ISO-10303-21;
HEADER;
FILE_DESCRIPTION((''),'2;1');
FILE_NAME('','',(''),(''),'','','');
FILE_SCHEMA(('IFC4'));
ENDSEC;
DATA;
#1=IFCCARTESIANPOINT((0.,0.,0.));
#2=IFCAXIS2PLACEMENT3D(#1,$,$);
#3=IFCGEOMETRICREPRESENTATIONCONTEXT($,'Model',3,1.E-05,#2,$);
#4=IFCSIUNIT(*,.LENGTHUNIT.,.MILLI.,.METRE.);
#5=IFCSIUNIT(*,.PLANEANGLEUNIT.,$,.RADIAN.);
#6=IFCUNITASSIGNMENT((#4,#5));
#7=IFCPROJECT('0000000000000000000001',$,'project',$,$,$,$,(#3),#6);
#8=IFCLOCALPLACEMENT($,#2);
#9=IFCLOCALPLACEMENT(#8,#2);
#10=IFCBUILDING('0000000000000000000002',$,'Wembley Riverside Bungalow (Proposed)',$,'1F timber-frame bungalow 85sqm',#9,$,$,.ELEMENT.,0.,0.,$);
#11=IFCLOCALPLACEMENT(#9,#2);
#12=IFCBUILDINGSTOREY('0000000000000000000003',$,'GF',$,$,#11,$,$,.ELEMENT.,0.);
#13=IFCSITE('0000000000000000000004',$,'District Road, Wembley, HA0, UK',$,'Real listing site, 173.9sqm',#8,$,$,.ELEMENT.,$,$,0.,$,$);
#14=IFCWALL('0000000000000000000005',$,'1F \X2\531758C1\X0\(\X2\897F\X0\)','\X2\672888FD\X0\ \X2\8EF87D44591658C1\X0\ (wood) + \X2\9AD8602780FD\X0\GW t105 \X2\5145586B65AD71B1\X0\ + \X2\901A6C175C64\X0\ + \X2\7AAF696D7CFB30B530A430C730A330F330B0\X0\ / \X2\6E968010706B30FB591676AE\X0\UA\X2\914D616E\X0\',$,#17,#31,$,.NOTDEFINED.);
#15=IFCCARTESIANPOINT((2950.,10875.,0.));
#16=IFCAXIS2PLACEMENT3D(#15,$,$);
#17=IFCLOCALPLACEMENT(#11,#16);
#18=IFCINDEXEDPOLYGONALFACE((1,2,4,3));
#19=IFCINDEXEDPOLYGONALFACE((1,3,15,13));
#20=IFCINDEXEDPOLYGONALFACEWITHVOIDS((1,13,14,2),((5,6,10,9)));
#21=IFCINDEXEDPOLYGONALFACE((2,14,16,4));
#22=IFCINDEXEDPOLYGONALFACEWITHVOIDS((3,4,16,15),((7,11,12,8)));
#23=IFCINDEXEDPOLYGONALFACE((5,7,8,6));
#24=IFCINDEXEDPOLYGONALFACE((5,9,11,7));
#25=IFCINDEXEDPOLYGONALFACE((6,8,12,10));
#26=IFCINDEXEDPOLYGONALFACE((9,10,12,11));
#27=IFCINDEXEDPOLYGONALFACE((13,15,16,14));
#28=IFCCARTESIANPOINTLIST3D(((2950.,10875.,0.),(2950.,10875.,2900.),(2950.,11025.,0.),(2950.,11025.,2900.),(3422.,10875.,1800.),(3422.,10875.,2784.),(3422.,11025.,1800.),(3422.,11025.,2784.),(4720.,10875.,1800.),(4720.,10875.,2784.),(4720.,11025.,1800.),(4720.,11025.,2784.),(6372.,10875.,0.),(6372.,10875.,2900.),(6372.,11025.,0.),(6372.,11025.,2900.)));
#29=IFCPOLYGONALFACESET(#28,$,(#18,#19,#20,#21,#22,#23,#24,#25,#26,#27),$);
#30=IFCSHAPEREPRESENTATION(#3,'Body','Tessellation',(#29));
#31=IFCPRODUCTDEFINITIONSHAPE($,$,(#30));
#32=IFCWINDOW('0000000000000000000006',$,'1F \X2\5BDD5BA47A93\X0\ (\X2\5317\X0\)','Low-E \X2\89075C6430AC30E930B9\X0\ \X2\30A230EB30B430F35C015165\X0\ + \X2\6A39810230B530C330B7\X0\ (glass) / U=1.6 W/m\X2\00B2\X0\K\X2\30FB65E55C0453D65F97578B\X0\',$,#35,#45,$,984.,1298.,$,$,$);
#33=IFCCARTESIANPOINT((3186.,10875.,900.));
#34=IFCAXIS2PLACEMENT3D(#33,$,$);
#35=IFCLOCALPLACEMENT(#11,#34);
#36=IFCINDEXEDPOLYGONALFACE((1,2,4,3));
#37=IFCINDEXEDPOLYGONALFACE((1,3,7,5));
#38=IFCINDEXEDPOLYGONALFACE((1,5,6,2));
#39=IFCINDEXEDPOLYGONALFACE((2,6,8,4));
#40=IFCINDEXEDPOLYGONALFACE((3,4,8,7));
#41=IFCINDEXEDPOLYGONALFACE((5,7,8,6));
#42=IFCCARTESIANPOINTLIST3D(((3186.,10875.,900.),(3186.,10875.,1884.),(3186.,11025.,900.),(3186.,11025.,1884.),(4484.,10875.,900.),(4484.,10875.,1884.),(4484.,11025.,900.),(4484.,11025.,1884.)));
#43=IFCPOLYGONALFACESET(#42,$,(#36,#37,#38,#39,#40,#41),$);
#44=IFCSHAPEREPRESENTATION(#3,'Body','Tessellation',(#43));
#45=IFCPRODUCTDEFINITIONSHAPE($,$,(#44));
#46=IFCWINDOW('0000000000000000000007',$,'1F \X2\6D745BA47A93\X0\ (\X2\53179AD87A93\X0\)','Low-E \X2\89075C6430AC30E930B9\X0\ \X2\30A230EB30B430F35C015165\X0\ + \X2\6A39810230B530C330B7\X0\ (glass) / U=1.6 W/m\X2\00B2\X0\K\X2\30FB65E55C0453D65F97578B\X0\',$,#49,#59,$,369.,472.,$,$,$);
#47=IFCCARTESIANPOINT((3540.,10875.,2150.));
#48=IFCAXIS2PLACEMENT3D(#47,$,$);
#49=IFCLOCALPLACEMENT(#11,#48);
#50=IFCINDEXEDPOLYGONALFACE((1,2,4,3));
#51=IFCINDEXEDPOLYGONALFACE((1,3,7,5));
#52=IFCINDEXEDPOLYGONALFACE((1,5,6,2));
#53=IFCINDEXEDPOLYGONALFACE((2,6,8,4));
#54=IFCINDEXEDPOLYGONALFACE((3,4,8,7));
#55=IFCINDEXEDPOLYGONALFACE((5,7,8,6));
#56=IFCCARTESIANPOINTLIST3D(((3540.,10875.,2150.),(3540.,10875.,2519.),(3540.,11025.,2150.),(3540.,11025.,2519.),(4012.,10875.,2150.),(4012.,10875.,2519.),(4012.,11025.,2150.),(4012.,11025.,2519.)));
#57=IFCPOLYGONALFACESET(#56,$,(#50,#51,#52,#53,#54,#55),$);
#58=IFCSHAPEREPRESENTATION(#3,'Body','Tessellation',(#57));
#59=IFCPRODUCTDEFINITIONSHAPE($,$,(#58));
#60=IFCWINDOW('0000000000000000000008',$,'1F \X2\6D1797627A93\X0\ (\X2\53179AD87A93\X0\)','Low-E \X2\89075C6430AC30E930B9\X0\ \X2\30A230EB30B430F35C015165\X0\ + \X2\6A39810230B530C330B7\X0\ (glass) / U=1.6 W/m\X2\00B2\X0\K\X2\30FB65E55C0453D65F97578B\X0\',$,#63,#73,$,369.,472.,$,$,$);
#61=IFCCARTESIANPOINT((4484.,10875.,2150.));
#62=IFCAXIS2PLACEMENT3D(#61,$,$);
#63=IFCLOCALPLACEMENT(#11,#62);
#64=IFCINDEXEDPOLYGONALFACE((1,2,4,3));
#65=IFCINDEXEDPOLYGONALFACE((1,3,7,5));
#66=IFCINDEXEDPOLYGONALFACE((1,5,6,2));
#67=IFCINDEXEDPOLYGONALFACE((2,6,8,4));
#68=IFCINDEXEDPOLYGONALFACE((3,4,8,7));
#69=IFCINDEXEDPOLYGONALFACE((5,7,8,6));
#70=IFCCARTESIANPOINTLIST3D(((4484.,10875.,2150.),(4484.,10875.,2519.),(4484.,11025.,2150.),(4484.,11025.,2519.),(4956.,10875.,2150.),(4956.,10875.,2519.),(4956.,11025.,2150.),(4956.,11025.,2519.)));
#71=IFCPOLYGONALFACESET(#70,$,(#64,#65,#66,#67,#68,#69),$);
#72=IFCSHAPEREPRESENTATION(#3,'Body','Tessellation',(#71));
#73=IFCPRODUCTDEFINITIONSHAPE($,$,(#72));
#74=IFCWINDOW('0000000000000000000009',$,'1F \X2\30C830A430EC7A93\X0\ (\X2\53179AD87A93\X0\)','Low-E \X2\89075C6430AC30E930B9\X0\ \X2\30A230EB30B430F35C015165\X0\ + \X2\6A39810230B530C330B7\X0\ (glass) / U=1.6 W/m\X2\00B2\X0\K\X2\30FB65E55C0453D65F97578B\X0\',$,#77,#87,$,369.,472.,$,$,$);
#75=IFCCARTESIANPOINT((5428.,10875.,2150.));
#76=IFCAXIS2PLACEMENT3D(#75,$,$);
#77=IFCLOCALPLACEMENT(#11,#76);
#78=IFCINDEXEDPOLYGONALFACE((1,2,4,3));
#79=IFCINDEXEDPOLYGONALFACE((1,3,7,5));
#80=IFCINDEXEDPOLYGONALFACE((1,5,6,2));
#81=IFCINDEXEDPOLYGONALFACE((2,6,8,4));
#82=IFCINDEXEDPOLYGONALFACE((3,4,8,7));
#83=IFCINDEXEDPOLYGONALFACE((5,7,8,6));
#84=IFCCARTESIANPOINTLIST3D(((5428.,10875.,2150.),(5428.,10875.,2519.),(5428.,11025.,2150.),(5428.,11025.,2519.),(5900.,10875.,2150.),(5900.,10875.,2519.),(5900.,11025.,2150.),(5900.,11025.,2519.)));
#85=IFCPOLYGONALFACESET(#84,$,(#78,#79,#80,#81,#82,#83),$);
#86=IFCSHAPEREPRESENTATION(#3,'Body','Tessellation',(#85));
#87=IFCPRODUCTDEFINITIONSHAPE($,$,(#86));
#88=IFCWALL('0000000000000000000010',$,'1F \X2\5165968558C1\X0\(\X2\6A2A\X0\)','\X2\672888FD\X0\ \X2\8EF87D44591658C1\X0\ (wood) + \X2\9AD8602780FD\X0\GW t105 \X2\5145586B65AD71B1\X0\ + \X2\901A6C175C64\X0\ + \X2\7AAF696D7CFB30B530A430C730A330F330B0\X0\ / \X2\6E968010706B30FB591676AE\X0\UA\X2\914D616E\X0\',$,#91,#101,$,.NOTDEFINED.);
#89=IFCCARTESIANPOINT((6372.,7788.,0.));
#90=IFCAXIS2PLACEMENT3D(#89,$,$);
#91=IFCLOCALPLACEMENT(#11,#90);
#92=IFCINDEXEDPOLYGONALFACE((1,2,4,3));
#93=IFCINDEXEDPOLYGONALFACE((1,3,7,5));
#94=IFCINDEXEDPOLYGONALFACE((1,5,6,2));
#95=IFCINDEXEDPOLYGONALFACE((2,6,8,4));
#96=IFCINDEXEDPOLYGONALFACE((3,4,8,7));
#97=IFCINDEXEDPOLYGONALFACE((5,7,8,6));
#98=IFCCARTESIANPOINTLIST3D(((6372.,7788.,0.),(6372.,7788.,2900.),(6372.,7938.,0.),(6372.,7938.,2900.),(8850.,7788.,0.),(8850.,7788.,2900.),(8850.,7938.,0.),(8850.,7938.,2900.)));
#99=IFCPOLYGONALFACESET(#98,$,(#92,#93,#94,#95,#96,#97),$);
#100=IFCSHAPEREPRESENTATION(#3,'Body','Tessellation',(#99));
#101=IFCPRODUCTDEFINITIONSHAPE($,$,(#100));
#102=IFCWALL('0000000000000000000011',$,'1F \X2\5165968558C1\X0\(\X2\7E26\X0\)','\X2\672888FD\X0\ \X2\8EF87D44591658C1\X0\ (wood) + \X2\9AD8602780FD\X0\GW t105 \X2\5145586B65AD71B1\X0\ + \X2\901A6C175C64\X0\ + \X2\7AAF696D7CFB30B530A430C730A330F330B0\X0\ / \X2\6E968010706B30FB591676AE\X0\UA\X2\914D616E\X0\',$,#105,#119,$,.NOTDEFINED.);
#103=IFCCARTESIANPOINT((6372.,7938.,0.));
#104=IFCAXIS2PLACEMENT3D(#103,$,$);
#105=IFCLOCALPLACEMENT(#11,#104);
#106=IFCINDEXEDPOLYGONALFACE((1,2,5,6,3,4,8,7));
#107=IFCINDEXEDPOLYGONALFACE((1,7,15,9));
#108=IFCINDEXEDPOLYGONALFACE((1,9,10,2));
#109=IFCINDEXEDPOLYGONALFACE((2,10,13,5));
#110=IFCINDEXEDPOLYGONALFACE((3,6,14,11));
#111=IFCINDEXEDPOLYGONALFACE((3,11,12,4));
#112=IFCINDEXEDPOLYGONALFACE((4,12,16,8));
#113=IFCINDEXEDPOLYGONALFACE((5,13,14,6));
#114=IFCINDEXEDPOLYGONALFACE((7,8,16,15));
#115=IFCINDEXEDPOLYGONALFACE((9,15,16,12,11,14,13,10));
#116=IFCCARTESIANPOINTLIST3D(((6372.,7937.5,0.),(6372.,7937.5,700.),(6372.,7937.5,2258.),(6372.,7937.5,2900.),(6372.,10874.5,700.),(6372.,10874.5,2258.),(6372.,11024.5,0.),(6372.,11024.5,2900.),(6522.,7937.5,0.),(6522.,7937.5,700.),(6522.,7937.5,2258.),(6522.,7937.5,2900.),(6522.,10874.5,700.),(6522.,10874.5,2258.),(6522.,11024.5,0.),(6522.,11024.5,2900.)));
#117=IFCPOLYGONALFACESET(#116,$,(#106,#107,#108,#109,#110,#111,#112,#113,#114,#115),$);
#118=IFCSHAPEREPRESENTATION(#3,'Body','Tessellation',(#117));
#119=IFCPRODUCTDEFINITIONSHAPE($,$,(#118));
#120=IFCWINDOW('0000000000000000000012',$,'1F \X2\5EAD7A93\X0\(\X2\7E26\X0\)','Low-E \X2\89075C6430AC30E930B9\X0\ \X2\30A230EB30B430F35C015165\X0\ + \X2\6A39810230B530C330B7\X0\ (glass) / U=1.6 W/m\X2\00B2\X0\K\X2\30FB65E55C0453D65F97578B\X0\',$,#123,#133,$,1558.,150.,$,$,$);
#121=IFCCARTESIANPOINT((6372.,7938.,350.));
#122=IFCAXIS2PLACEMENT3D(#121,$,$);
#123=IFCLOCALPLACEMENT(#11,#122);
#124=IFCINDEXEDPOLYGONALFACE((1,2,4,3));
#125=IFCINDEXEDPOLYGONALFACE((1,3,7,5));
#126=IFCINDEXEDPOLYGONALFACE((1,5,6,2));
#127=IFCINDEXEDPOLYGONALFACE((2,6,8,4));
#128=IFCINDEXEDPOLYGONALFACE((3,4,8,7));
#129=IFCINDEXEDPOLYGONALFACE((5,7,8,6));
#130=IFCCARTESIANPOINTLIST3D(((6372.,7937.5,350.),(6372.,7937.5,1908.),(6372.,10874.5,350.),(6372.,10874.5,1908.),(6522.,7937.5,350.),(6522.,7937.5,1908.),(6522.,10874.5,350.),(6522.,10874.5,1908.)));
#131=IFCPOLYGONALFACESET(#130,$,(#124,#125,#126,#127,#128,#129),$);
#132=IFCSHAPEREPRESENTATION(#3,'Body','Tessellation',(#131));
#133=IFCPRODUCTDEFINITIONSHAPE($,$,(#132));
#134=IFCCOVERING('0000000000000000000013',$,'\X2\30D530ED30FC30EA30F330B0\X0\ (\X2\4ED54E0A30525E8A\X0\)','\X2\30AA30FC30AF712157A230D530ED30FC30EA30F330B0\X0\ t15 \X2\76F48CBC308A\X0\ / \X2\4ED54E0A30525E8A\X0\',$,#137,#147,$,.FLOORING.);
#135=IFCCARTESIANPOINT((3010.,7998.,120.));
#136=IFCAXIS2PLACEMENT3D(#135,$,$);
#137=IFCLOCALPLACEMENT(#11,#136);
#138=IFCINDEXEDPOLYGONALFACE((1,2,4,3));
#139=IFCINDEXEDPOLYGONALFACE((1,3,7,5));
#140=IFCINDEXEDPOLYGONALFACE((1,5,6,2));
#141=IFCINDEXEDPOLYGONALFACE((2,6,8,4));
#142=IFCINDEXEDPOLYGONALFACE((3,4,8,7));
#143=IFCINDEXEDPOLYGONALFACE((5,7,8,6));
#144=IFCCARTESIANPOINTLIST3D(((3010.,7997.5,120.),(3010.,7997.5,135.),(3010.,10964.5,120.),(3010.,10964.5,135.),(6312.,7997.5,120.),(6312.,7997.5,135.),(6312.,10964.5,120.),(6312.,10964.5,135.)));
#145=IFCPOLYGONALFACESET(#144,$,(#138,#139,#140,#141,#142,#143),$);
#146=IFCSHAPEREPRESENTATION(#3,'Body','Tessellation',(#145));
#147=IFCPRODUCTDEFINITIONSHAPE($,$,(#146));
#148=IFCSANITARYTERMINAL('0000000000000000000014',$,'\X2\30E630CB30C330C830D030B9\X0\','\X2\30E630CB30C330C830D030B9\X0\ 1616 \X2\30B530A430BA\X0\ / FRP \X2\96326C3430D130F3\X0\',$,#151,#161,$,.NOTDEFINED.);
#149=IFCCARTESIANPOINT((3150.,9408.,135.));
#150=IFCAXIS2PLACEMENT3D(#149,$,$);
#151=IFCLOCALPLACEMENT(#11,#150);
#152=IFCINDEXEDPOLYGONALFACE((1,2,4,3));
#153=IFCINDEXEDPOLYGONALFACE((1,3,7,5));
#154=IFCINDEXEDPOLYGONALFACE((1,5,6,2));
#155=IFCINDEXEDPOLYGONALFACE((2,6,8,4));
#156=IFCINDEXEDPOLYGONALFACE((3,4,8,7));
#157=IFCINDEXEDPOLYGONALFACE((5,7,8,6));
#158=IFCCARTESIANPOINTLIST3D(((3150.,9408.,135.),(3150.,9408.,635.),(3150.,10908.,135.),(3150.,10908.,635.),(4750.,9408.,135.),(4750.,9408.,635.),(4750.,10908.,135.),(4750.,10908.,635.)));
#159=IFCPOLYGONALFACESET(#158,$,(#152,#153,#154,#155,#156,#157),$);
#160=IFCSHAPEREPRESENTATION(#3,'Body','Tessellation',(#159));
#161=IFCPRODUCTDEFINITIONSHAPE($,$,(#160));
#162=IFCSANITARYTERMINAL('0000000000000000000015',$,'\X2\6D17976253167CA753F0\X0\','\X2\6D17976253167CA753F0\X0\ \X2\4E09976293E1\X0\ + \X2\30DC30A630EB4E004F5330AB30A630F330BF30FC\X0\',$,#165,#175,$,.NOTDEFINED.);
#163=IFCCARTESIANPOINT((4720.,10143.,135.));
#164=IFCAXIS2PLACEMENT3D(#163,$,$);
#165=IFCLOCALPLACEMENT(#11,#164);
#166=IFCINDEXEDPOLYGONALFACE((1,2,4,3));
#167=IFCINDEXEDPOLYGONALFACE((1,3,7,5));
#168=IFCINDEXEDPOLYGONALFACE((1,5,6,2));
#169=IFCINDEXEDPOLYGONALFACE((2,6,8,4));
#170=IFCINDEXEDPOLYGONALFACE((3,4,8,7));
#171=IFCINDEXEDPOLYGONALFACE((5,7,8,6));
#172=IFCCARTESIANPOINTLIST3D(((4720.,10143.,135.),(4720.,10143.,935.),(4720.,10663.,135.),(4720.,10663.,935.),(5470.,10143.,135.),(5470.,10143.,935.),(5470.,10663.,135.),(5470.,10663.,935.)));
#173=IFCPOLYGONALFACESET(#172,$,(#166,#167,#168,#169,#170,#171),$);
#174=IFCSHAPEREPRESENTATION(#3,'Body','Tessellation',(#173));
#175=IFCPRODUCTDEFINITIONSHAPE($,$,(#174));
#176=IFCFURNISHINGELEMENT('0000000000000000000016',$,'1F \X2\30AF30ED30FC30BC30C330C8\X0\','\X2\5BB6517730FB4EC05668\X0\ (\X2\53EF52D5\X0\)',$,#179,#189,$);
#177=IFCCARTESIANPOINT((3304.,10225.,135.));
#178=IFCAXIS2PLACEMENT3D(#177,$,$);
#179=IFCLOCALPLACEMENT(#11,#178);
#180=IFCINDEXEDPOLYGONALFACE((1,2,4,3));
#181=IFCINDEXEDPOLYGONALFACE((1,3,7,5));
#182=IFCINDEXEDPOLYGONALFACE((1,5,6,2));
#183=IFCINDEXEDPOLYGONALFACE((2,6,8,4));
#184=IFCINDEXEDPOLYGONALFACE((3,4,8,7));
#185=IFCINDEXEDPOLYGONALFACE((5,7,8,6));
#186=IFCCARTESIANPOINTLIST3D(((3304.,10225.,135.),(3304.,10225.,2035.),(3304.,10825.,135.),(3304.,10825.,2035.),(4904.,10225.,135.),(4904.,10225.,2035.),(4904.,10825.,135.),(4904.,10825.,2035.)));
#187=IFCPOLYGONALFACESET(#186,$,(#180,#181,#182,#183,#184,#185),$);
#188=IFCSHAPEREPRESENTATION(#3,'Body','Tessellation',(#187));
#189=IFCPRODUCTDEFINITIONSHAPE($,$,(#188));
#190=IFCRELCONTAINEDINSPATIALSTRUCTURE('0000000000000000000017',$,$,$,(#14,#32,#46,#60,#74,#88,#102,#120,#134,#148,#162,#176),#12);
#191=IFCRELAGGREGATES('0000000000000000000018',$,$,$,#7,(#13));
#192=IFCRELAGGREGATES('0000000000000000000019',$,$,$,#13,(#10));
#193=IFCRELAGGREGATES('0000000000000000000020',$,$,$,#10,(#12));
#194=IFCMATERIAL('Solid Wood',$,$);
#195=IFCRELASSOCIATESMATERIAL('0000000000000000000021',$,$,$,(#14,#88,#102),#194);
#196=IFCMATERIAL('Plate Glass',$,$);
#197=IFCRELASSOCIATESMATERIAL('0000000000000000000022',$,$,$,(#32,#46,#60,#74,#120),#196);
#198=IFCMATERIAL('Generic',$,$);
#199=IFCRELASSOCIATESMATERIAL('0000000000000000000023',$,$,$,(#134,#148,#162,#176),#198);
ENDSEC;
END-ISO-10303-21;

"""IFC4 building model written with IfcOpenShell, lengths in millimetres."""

from ifc_helpers import new_model, si_unit, frame, frame_2d, origin, place, context, project, spatial, rectangle, extrude, material, element, fill, save


model = new_model("IFC4")

# Units and contexts
model_context = context("Model", 3, precision=1e-05, world=origin())
ifc_project = project(units=[si_unit("LENGTHUNIT", "METRE", prefix="MILLI"), si_unit("PLANEANGLEUNIT", "RADIAN")], contexts=[model_context])

# Site, building, storey
site_placement = place(None, origin())
site = spatial("IfcSite", under=ifc_project, at=site_placement, Name="District Road, Wembley, HA0, UK", ObjectType="Real listing site, 173.9sqm", CompositionType="ELEMENT", RefElevation=0.0)
building_placement = place(site_placement, origin())
building = spatial("IfcBuilding", under=site, at=building_placement, Name="Wembley Riverside Bungalow (Proposed)", ObjectType="1F timber-frame bungalow 85sqm", CompositionType="ELEMENT", ElevationOfRefHeight=0.0, ElevationOfTerrain=0.0)
storey_placement = place(building_placement, origin())
storey = spatial("IfcBuildingStorey", under=building, at=storey_placement, Name="GF", CompositionType="ELEMENT", Elevation=0.0)

# Shared definitions
ifc_material_1 = material(Name="Solid Wood")

# Wall, openings, windows
wall_1_placement = place(storey_placement, frame((2950.0, 10875.0, 0.0)))
wall_1 = element("IfcWall", 1, at=wall_1_placement, inside=storey, material=ifc_material_1, Name="1F 北壁(西)", Description="木製 軸組外壁 (wood) + 高性能GW t105 充填断熱 + 通気層 + 窯業系サイディング / 準耐火・外皮UA配慮", PredefinedType="NOTDEFINED", context=model_context, shape_type="SweptSolid", body=[
    extrude(rectangle(XDim=3422.0, YDim=150.0, at=frame_2d((1711.0, 75.0))), frame((2950.0, 10875.0, 0.0)), (0.0, 0.0, 1.0), 2900.0),
])
opening_1_placement = place(storey_placement, frame((3186.0, 10875.0, 900.0)))
opening_1 = element("IfcOpeningElement", 2, at=opening_1_placement, cuts=wall_1, PredefinedType="NOTDEFINED", context=model_context, shape_type="SweptSolid", body=[
    extrude(rectangle(XDim=1298.0, YDim=150.0, at=frame_2d((649.0, 75.0))), frame((3186.0, 10875.0, 900.0)), (0.0, 0.0, 1.0), 984.0),
])
opening_2_placement = place(storey_placement, frame((3540.0, 10875.0, 2150.0)))
opening_2 = element("IfcOpeningElement", 3, at=opening_2_placement, cuts=wall_1, PredefinedType="NOTDEFINED", context=model_context, shape_type="SweptSolid", body=[
    extrude(rectangle(XDim=472.0, YDim=150.0, at=frame_2d((236.0, 75.0))), frame((3540.0, 10875.0, 2150.0)), (0.0, 0.0, 1.0), 369.0),
])
opening_3_placement = place(storey_placement, frame((4484.0, 10875.0, 2150.0)))
opening_3 = element("IfcOpeningElement", 4, at=opening_3_placement, cuts=wall_1, PredefinedType="NOTDEFINED", context=model_context, shape_type="SweptSolid", body=[
    extrude(rectangle(XDim=472.0, YDim=150.0, at=frame_2d((236.0, 75.0))), frame((4484.0, 10875.0, 2150.0)), (0.0, 0.0, 1.0), 369.0),
])
opening_4_placement = place(storey_placement, frame((5428.0, 10875.0, 2150.0)))
opening_4 = element("IfcOpeningElement", 5, at=opening_4_placement, cuts=wall_1, PredefinedType="NOTDEFINED", context=model_context, shape_type="SweptSolid", body=[
    extrude(rectangle(XDim=472.0, YDim=150.0, at=frame_2d((236.0, 75.0))), frame((5428.0, 10875.0, 2150.0)), (0.0, 0.0, 1.0), 369.0),
])
ifc_material_2 = material(Name="Plate Glass")
window_1_placement = place(storey_placement, frame((3186.0, 10875.0, 900.0)))
window_1 = element("IfcWindow", 6, at=window_1_placement, inside=storey, material=ifc_material_2, Name="1F 寝室窓 (北)", Description="Low-E 複層ガラス アルゴン封入 + 樹脂サッシ (glass) / U=1.6 W/m²K・日射取得型", OverallHeight=984.0, OverallWidth=1298.0, context=model_context, shape_type="SweptSolid", body=[
    extrude(rectangle(XDim=1298.0, YDim=150.0, at=frame_2d((649.0, 75.0))), frame((3186.0, 10875.0, 900.0)), (0.0, 0.0, 1.0), 984.0),
])
fill(opening_1, window_1)
window_2_placement = place(storey_placement, frame((3540.0, 10875.0, 2150.0)))
window_2 = element("IfcWindow", 7, at=window_2_placement, inside=storey, material=ifc_material_2, Name="1F 浴室窓 (北高窓)", Description="Low-E 複層ガラス アルゴン封入 + 樹脂サッシ (glass) / U=1.6 W/m²K・日射取得型", OverallHeight=369.0, OverallWidth=472.0, context=model_context, shape_type="SweptSolid", body=[
    extrude(rectangle(XDim=472.0, YDim=150.0, at=frame_2d((236.0, 75.0))), frame((3540.0, 10875.0, 2150.0)), (0.0, 0.0, 1.0), 369.0),
])
fill(opening_2, window_2)
window_3_placement = place(storey_placement, frame((4484.0, 10875.0, 2150.0)))
window_3 = element("IfcWindow", 8, at=window_3_placement, inside=storey, material=ifc_material_2, Name="1F 洗面窓 (北高窓)", Description="Low-E 複層ガラス アルゴン封入 + 樹脂サッシ (glass) / U=1.6 W/m²K・日射取得型", OverallHeight=369.0, OverallWidth=472.0, context=model_context, shape_type="SweptSolid", body=[
    extrude(rectangle(XDim=472.0, YDim=150.0, at=frame_2d((236.0, 75.0))), frame((4484.0, 10875.0, 2150.0)), (0.0, 0.0, 1.0), 369.0),
])
fill(opening_3, window_3)
window_4_placement = place(storey_placement, frame((5428.0, 10875.0, 2150.0)))
window_4 = element("IfcWindow", 9, at=window_4_placement, inside=storey, material=ifc_material_2, Name="1F トイレ窓 (北高窓)", Description="Low-E 複層ガラス アルゴン封入 + 樹脂サッシ (glass) / U=1.6 W/m²K・日射取得型", OverallHeight=369.0, OverallWidth=472.0, context=model_context, shape_type="SweptSolid", body=[
    extrude(rectangle(XDim=472.0, YDim=150.0, at=frame_2d((236.0, 75.0))), frame((5428.0, 10875.0, 2150.0)), (0.0, 0.0, 1.0), 369.0),
])
fill(opening_4, window_4)

# Wall
wall_2_placement = place(storey_placement, frame((6372.0, 7788.0, 0.0)))
element("IfcWall", 10, at=wall_2_placement, inside=storey, material=ifc_material_1, Name="1F 入隅壁(横)", Description="木製 軸組外壁 (wood) + 高性能GW t105 充填断熱 + 通気層 + 窯業系サイディング / 準耐火・外皮UA配慮", PredefinedType="NOTDEFINED", context=model_context, shape_type="SweptSolid", body=[
    extrude(rectangle(XDim=2478.0, YDim=150.0, at=frame_2d((1239.0, 75.0))), frame((6372.0, 7788.0, 0.0)), (0.0, 0.0, 1.0), 2900.0),
])

# Wall, opening, window
wall_3_placement = place(storey_placement, frame((6372.0, 7938.0, 0.0)))
wall_3 = element("IfcWall", 11, at=wall_3_placement, inside=storey, material=ifc_material_1, Name="1F 入隅壁(縦)", Description="木製 軸組外壁 (wood) + 高性能GW t105 充填断熱 + 通気層 + 窯業系サイディング / 準耐火・外皮UA配慮", PredefinedType="NOTDEFINED", context=model_context, shape_type="SweptSolid", body=[
    extrude(rectangle(XDim=150.0, YDim=3087.0, at=frame_2d((75.0, 1543.0))), frame((6372.0, 7938.0, 0.0)), (0.0, 0.0, 1.0), 2900.0),
])
opening_5_placement = place(storey_placement, frame((6372.0, 7938.0, 350.0)))
opening_5 = element("IfcOpeningElement", 12, at=opening_5_placement, cuts=wall_3, PredefinedType="NOTDEFINED", context=model_context, shape_type="SweptSolid", body=[
    extrude(rectangle(XDim=150.0, YDim=2937.0, at=frame_2d((75.0, 1468.0))), frame((6372.0, 7938.0, 350.0)), (0.0, 0.0, 1.0), 1558.0),
])
window_5_placement = place(storey_placement, frame((6372.0, 7938.0, 350.0)))
window_5 = element("IfcWindow", 13, at=window_5_placement, inside=storey, material=ifc_material_2, Name="1F 庭窓(縦)", Description="Low-E 複層ガラス アルゴン封入 + 樹脂サッシ (glass) / U=1.6 W/m²K・日射取得型", OverallHeight=1558.0, OverallWidth=150.0, context=model_context, shape_type="SweptSolid", body=[
    extrude(rectangle(XDim=150.0, YDim=2937.0, at=frame_2d((75.0, 1468.0))), frame((6372.0, 7938.0, 350.0)), (0.0, 0.0, 1.0), 1558.0),
])
fill(opening_5, window_5)

# Covering
ifc_material_3 = material(Name="Generic")
covering_placement = place(storey_placement, frame((3010.0, 7998.0, 120.0)))
element("IfcCovering", 14, at=covering_placement, inside=storey, material=ifc_material_3, Name="フローリング (仕上げ床)", Description="オーク無垢フローリング t15 直貼り / 仕上げ床", PredefinedType="FLOORING", context=model_context, shape_type="SweptSolid", body=[
    extrude(rectangle(XDim=3302.0, YDim=2967.0, at=frame_2d((1651.0, 1483.0))), frame((3010.0, 7998.0, 120.0)), (0.0, 0.0, 1.0), 15.0),
])

# Sanitary terminals
sanitary_terminal_1_placement = place(storey_placement, frame((3150.0, 9408.0, 135.0)))
element("IfcSanitaryTerminal", 15, at=sanitary_terminal_1_placement, inside=storey, material=ifc_material_3, Name="ユニットバス", Description="ユニットバス 1616 サイズ / FRP 防水パン", PredefinedType="NOTDEFINED", context=model_context, shape_type="SweptSolid", body=[
    extrude(rectangle(XDim=1600.0, YDim=1500.0, at=frame_2d((800.0, 750.0))), frame((3150.0, 9408.0, 135.0)), (0.0, 0.0, 1.0), 500.0),
])
sanitary_terminal_2_placement = place(storey_placement, frame((4720.0, 10143.0, 135.0)))
element("IfcSanitaryTerminal", 16, at=sanitary_terminal_2_placement, inside=storey, material=ifc_material_3, Name="洗面化粧台", Description="洗面化粧台 三面鏡 + ボウル一体カウンター", PredefinedType="NOTDEFINED", context=model_context, shape_type="SweptSolid", body=[
    extrude(rectangle(XDim=750.0, YDim=520.0, at=frame_2d((375.0, 260.0))), frame((4720.0, 10143.0, 135.0)), (0.0, 0.0, 1.0), 800.0),
])

# Furnishing element
furnishing_1_placement = place(storey_placement, frame((3304.0, 10225.0, 135.0)))
element("IfcFurnishingElement", 17, at=furnishing_1_placement, inside=storey, material=ifc_material_3, Name="1F クローゼット", Description="家具・什器 (可動)", context=model_context, shape_type="SweptSolid", body=[
    extrude(rectangle(XDim=1600.0, YDim=600.0, at=frame_2d((800.0, 300.0))), frame((3304.0, 10225.0, 135.0)), (0.0, 0.0, 1.0), 1900.0),
])

save(model, "model.ifc")
